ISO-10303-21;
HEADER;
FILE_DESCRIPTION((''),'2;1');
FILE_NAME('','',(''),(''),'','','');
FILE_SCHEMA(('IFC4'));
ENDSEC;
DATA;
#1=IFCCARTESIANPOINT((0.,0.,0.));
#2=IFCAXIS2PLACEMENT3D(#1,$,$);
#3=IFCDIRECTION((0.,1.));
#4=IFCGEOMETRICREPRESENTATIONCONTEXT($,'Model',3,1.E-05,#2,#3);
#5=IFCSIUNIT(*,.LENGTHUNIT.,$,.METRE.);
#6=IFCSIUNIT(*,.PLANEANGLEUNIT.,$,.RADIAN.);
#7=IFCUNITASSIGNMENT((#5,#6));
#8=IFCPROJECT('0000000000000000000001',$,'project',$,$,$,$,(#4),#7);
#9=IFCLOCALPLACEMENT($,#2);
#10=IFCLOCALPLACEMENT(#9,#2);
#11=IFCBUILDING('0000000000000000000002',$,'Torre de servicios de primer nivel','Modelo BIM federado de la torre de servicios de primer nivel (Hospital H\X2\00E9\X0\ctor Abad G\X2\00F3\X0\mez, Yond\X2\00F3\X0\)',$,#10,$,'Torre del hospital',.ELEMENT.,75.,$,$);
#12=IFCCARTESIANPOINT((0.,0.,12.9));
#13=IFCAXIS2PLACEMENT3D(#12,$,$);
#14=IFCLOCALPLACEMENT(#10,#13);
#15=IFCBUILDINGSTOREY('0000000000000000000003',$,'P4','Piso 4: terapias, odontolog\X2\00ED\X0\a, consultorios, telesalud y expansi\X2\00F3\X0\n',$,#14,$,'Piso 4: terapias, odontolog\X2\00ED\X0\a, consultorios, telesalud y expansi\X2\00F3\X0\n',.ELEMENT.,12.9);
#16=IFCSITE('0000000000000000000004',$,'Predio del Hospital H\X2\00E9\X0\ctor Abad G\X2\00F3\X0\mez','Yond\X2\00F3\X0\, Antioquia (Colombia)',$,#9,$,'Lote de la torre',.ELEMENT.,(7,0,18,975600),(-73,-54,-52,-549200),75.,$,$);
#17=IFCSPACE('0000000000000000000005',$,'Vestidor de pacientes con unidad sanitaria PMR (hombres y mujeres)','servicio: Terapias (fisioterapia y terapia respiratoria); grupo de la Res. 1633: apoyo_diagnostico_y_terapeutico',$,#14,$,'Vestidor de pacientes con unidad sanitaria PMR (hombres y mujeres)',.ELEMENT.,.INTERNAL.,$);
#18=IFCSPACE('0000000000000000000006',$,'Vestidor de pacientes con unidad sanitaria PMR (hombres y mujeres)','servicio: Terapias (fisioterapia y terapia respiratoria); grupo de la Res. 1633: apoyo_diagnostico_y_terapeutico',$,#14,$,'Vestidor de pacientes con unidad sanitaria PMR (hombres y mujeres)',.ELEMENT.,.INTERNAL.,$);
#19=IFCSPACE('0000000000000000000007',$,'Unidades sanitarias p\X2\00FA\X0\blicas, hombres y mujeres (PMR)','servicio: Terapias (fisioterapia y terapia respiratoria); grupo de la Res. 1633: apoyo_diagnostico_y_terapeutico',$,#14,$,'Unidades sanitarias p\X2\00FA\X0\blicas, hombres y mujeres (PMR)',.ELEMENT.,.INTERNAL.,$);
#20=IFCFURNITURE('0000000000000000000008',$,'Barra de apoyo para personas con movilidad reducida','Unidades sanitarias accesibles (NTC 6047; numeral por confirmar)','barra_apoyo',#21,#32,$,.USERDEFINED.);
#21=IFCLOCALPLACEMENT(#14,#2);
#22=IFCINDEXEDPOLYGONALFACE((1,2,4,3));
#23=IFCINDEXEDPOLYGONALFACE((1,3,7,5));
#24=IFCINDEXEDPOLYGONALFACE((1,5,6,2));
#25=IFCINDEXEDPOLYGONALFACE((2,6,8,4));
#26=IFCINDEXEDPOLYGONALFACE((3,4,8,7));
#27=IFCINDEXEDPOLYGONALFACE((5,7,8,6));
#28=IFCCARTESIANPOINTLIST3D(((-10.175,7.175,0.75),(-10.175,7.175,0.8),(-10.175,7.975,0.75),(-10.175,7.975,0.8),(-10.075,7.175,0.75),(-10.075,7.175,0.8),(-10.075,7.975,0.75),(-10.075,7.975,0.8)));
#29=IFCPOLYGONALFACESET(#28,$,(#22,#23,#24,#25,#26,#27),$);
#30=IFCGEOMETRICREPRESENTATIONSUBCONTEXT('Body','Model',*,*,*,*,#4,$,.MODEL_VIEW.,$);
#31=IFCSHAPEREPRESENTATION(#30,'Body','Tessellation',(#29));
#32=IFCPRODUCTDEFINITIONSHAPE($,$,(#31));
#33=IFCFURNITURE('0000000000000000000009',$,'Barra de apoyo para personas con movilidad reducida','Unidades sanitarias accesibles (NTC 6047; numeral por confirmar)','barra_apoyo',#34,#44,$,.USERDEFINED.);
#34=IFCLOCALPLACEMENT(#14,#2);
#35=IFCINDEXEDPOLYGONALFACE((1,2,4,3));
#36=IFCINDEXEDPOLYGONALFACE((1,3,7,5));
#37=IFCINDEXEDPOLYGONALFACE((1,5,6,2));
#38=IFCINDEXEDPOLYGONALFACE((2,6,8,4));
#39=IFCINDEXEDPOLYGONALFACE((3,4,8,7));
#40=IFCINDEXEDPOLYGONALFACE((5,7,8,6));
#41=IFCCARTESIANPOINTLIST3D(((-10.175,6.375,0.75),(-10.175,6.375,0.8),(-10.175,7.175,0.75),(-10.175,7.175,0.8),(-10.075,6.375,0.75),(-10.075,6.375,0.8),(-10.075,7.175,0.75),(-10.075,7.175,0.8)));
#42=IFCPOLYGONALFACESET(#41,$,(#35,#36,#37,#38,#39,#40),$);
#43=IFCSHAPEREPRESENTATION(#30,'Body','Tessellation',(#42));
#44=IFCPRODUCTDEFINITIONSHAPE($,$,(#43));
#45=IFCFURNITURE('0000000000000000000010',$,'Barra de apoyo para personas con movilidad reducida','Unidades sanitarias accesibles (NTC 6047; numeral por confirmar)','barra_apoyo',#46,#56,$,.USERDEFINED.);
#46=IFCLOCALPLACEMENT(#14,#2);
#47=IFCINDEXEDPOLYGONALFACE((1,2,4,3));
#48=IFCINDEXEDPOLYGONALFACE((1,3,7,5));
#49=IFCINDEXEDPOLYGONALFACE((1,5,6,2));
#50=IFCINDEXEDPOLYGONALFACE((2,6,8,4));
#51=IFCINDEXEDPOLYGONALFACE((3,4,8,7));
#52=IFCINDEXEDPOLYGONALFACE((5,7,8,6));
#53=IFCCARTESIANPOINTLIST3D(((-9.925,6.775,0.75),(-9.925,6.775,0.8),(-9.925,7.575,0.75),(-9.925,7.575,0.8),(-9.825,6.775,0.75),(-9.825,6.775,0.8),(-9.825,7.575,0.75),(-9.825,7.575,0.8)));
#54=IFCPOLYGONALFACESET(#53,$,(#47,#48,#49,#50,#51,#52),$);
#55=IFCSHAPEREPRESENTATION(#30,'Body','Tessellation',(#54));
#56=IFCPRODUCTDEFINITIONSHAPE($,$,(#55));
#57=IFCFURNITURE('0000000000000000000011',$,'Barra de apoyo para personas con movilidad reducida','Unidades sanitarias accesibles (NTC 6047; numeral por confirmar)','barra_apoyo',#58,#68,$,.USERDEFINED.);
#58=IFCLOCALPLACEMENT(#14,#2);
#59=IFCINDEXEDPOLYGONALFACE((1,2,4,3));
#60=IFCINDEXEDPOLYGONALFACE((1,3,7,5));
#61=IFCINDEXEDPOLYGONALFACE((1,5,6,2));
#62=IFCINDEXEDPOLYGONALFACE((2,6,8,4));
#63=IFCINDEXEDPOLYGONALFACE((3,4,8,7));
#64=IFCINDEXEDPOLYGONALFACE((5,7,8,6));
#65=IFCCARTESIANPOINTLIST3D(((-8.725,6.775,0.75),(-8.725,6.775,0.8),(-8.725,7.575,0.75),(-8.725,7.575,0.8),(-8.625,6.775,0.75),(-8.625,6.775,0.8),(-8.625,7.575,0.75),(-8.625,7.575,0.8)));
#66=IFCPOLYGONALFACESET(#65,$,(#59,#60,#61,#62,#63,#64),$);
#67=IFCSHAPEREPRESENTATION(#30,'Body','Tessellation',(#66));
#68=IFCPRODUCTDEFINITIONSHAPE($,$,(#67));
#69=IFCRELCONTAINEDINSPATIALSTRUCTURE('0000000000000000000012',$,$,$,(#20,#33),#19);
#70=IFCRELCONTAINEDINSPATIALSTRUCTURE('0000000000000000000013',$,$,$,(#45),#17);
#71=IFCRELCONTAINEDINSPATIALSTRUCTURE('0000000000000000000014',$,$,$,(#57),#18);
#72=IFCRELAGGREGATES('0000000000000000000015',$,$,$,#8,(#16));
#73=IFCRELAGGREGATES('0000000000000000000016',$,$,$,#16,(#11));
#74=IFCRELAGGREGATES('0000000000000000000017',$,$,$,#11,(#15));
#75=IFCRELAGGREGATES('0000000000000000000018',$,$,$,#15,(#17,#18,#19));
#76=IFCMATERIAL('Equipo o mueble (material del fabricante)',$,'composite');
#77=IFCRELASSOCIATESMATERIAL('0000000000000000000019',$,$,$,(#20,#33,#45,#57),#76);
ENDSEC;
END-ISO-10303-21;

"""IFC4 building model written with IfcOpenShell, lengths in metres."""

from ifc_helpers import new_model, si_unit, direction, frame, origin, place, context, subcontext, project, spatial, rectangle, extrude, material, element, save


model = new_model("IFC4")

# Units and contexts
model_context = context("Model", 3, precision=1e-05, world=origin(), true_north=direction((0.0, 1.0)))
body_context = subcontext(model_context, "Body", "Model", "MODEL_VIEW")
ifc_project = project(units=[si_unit("LENGTHUNIT", "METRE"), si_unit("PLANEANGLEUNIT", "RADIAN")], contexts=[model_context])

# Site, building, storey
site_placement = place(None, origin())
site = spatial("IfcSite", under=ifc_project, at=site_placement, Name="Predio del Hospital Héctor Abad Gómez", Description="Yondó, Antioquia (Colombia)", LongName="Lote de la torre", CompositionType="ELEMENT", RefLatitude=(7, 0, 18, 975600), RefLongitude=(-73, -54, -52, -549200), RefElevation=75.0)
building_placement = place(site_placement, origin())
building = spatial("IfcBuilding", under=site, at=building_placement, Name="Torre de servicios de primer nivel", Description="Modelo BIM federado de la torre de servicios de primer nivel (Hospital Héctor Abad Gómez, Yondó)", LongName="Torre del hospital", CompositionType="ELEMENT", ElevationOfRefHeight=75.0)
placement = place(building_placement, frame((0.0, 0.0, 12.9)))
storey = spatial("IfcBuildingStorey", under=building, at=placement, Name="P4", Description="Piso 4: terapias, odontología, consultorios, telesalud y expansión", LongName="Piso 4: terapias, odontología, consultorios, telesalud y expansión", CompositionType="ELEMENT", Elevation=12.9)

# Shared definitions
ifc_material = material(Name="Equipo o mueble (material del fabricante)", Category="composite")

# Shared definitions
space_1 = spatial("IfcSpace", under=storey, at=placement, Name="Vestidor de pacientes con unidad sanitaria PMR (hombres y mujeres)", Description="servicio: Terapias (fisioterapia y terapia respiratoria); grupo de la Res. 1633: apoyo_diagnostico_y_terapeutico", LongName="Vestidor de pacientes con unidad sanitaria PMR (hombres y mujeres)", CompositionType="ELEMENT", PredefinedType="INTERNAL")

# Shared definitions
space_2 = spatial("IfcSpace", under=storey, at=placement, Name="Vestidor de pacientes con unidad sanitaria PMR (hombres y mujeres)", Description="servicio: Terapias (fisioterapia y terapia respiratoria); grupo de la Res. 1633: apoyo_diagnostico_y_terapeutico", LongName="Vestidor de pacientes con unidad sanitaria PMR (hombres y mujeres)", CompositionType="ELEMENT", PredefinedType="INTERNAL")

# Shared definitions
space_3 = spatial("IfcSpace", under=storey, at=placement, Name="Unidades sanitarias públicas, hombres y mujeres (PMR)", Description="servicio: Terapias (fisioterapia y terapia respiratoria); grupo de la Res. 1633: apoyo_diagnostico_y_terapeutico", LongName="Unidades sanitarias públicas, hombres y mujeres (PMR)", CompositionType="ELEMENT", PredefinedType="INTERNAL")

# Furniture
element("IfcFurniture", 1, at=placement, inside=space_3, material=ifc_material, Name="Barra de apoyo para personas con movilidad reducida", Description="Unidades sanitarias accesibles (NTC 6047; numeral por confirmar)", ObjectType="barra_apoyo", PredefinedType="USERDEFINED", context=body_context, shape_type="SweptSolid", body=[
    extrude(rectangle(XDim=0.8, YDim=0.1), frame((-10.125, 7.575, 0.75), z_axis=(0.0, 0.0, 1.0), x_axis=(0.0, 1.0, 0.0)), (0.0, 0.0, 1.0), 0.05),
])
element("IfcFurniture", 2, at=placement, inside=space_3, material=ifc_material, Name="Barra de apoyo para personas con movilidad reducida", Description="Unidades sanitarias accesibles (NTC 6047; numeral por confirmar)", ObjectType="barra_apoyo", PredefinedType="USERDEFINED", context=body_context, shape_type="SweptSolid", body=[
    extrude(rectangle(XDim=0.8, YDim=0.1), frame((-10.125, 6.775, 0.75), z_axis=(0.0, 0.0, 1.0), x_axis=(0.0, 1.0, 0.0)), (0.0, 0.0, 1.0), 0.05),
])
element("IfcFurniture", 3, at=placement, inside=space_1, material=ifc_material, Name="Barra de apoyo para personas con movilidad reducida", Description="Unidades sanitarias accesibles (NTC 6047; numeral por confirmar)", ObjectType="barra_apoyo", PredefinedType="USERDEFINED", context=body_context, shape_type="SweptSolid", body=[
    extrude(rectangle(XDim=0.8, YDim=0.1), frame((-9.875, 7.175, 0.75), z_axis=(0.0, 0.0, 1.0), x_axis=(0.0, -1.0, 0.0)), (0.0, 0.0, 1.0), 0.05),
])
element("IfcFurniture", 4, at=placement, inside=space_2, material=ifc_material, Name="Barra de apoyo para personas con movilidad reducida", Description="Unidades sanitarias accesibles (NTC 6047; numeral por confirmar)", ObjectType="barra_apoyo", PredefinedType="USERDEFINED", context=body_context, shape_type="SweptSolid", body=[
    extrude(rectangle(XDim=0.8, YDim=0.1), frame((-8.675, 7.175, 0.75), z_axis=(0.0, 0.0, 1.0), x_axis=(0.0, -1.0, 0.0)), (0.0, 0.0, 1.0), 0.05),
])

save(model, "model.ifc")
